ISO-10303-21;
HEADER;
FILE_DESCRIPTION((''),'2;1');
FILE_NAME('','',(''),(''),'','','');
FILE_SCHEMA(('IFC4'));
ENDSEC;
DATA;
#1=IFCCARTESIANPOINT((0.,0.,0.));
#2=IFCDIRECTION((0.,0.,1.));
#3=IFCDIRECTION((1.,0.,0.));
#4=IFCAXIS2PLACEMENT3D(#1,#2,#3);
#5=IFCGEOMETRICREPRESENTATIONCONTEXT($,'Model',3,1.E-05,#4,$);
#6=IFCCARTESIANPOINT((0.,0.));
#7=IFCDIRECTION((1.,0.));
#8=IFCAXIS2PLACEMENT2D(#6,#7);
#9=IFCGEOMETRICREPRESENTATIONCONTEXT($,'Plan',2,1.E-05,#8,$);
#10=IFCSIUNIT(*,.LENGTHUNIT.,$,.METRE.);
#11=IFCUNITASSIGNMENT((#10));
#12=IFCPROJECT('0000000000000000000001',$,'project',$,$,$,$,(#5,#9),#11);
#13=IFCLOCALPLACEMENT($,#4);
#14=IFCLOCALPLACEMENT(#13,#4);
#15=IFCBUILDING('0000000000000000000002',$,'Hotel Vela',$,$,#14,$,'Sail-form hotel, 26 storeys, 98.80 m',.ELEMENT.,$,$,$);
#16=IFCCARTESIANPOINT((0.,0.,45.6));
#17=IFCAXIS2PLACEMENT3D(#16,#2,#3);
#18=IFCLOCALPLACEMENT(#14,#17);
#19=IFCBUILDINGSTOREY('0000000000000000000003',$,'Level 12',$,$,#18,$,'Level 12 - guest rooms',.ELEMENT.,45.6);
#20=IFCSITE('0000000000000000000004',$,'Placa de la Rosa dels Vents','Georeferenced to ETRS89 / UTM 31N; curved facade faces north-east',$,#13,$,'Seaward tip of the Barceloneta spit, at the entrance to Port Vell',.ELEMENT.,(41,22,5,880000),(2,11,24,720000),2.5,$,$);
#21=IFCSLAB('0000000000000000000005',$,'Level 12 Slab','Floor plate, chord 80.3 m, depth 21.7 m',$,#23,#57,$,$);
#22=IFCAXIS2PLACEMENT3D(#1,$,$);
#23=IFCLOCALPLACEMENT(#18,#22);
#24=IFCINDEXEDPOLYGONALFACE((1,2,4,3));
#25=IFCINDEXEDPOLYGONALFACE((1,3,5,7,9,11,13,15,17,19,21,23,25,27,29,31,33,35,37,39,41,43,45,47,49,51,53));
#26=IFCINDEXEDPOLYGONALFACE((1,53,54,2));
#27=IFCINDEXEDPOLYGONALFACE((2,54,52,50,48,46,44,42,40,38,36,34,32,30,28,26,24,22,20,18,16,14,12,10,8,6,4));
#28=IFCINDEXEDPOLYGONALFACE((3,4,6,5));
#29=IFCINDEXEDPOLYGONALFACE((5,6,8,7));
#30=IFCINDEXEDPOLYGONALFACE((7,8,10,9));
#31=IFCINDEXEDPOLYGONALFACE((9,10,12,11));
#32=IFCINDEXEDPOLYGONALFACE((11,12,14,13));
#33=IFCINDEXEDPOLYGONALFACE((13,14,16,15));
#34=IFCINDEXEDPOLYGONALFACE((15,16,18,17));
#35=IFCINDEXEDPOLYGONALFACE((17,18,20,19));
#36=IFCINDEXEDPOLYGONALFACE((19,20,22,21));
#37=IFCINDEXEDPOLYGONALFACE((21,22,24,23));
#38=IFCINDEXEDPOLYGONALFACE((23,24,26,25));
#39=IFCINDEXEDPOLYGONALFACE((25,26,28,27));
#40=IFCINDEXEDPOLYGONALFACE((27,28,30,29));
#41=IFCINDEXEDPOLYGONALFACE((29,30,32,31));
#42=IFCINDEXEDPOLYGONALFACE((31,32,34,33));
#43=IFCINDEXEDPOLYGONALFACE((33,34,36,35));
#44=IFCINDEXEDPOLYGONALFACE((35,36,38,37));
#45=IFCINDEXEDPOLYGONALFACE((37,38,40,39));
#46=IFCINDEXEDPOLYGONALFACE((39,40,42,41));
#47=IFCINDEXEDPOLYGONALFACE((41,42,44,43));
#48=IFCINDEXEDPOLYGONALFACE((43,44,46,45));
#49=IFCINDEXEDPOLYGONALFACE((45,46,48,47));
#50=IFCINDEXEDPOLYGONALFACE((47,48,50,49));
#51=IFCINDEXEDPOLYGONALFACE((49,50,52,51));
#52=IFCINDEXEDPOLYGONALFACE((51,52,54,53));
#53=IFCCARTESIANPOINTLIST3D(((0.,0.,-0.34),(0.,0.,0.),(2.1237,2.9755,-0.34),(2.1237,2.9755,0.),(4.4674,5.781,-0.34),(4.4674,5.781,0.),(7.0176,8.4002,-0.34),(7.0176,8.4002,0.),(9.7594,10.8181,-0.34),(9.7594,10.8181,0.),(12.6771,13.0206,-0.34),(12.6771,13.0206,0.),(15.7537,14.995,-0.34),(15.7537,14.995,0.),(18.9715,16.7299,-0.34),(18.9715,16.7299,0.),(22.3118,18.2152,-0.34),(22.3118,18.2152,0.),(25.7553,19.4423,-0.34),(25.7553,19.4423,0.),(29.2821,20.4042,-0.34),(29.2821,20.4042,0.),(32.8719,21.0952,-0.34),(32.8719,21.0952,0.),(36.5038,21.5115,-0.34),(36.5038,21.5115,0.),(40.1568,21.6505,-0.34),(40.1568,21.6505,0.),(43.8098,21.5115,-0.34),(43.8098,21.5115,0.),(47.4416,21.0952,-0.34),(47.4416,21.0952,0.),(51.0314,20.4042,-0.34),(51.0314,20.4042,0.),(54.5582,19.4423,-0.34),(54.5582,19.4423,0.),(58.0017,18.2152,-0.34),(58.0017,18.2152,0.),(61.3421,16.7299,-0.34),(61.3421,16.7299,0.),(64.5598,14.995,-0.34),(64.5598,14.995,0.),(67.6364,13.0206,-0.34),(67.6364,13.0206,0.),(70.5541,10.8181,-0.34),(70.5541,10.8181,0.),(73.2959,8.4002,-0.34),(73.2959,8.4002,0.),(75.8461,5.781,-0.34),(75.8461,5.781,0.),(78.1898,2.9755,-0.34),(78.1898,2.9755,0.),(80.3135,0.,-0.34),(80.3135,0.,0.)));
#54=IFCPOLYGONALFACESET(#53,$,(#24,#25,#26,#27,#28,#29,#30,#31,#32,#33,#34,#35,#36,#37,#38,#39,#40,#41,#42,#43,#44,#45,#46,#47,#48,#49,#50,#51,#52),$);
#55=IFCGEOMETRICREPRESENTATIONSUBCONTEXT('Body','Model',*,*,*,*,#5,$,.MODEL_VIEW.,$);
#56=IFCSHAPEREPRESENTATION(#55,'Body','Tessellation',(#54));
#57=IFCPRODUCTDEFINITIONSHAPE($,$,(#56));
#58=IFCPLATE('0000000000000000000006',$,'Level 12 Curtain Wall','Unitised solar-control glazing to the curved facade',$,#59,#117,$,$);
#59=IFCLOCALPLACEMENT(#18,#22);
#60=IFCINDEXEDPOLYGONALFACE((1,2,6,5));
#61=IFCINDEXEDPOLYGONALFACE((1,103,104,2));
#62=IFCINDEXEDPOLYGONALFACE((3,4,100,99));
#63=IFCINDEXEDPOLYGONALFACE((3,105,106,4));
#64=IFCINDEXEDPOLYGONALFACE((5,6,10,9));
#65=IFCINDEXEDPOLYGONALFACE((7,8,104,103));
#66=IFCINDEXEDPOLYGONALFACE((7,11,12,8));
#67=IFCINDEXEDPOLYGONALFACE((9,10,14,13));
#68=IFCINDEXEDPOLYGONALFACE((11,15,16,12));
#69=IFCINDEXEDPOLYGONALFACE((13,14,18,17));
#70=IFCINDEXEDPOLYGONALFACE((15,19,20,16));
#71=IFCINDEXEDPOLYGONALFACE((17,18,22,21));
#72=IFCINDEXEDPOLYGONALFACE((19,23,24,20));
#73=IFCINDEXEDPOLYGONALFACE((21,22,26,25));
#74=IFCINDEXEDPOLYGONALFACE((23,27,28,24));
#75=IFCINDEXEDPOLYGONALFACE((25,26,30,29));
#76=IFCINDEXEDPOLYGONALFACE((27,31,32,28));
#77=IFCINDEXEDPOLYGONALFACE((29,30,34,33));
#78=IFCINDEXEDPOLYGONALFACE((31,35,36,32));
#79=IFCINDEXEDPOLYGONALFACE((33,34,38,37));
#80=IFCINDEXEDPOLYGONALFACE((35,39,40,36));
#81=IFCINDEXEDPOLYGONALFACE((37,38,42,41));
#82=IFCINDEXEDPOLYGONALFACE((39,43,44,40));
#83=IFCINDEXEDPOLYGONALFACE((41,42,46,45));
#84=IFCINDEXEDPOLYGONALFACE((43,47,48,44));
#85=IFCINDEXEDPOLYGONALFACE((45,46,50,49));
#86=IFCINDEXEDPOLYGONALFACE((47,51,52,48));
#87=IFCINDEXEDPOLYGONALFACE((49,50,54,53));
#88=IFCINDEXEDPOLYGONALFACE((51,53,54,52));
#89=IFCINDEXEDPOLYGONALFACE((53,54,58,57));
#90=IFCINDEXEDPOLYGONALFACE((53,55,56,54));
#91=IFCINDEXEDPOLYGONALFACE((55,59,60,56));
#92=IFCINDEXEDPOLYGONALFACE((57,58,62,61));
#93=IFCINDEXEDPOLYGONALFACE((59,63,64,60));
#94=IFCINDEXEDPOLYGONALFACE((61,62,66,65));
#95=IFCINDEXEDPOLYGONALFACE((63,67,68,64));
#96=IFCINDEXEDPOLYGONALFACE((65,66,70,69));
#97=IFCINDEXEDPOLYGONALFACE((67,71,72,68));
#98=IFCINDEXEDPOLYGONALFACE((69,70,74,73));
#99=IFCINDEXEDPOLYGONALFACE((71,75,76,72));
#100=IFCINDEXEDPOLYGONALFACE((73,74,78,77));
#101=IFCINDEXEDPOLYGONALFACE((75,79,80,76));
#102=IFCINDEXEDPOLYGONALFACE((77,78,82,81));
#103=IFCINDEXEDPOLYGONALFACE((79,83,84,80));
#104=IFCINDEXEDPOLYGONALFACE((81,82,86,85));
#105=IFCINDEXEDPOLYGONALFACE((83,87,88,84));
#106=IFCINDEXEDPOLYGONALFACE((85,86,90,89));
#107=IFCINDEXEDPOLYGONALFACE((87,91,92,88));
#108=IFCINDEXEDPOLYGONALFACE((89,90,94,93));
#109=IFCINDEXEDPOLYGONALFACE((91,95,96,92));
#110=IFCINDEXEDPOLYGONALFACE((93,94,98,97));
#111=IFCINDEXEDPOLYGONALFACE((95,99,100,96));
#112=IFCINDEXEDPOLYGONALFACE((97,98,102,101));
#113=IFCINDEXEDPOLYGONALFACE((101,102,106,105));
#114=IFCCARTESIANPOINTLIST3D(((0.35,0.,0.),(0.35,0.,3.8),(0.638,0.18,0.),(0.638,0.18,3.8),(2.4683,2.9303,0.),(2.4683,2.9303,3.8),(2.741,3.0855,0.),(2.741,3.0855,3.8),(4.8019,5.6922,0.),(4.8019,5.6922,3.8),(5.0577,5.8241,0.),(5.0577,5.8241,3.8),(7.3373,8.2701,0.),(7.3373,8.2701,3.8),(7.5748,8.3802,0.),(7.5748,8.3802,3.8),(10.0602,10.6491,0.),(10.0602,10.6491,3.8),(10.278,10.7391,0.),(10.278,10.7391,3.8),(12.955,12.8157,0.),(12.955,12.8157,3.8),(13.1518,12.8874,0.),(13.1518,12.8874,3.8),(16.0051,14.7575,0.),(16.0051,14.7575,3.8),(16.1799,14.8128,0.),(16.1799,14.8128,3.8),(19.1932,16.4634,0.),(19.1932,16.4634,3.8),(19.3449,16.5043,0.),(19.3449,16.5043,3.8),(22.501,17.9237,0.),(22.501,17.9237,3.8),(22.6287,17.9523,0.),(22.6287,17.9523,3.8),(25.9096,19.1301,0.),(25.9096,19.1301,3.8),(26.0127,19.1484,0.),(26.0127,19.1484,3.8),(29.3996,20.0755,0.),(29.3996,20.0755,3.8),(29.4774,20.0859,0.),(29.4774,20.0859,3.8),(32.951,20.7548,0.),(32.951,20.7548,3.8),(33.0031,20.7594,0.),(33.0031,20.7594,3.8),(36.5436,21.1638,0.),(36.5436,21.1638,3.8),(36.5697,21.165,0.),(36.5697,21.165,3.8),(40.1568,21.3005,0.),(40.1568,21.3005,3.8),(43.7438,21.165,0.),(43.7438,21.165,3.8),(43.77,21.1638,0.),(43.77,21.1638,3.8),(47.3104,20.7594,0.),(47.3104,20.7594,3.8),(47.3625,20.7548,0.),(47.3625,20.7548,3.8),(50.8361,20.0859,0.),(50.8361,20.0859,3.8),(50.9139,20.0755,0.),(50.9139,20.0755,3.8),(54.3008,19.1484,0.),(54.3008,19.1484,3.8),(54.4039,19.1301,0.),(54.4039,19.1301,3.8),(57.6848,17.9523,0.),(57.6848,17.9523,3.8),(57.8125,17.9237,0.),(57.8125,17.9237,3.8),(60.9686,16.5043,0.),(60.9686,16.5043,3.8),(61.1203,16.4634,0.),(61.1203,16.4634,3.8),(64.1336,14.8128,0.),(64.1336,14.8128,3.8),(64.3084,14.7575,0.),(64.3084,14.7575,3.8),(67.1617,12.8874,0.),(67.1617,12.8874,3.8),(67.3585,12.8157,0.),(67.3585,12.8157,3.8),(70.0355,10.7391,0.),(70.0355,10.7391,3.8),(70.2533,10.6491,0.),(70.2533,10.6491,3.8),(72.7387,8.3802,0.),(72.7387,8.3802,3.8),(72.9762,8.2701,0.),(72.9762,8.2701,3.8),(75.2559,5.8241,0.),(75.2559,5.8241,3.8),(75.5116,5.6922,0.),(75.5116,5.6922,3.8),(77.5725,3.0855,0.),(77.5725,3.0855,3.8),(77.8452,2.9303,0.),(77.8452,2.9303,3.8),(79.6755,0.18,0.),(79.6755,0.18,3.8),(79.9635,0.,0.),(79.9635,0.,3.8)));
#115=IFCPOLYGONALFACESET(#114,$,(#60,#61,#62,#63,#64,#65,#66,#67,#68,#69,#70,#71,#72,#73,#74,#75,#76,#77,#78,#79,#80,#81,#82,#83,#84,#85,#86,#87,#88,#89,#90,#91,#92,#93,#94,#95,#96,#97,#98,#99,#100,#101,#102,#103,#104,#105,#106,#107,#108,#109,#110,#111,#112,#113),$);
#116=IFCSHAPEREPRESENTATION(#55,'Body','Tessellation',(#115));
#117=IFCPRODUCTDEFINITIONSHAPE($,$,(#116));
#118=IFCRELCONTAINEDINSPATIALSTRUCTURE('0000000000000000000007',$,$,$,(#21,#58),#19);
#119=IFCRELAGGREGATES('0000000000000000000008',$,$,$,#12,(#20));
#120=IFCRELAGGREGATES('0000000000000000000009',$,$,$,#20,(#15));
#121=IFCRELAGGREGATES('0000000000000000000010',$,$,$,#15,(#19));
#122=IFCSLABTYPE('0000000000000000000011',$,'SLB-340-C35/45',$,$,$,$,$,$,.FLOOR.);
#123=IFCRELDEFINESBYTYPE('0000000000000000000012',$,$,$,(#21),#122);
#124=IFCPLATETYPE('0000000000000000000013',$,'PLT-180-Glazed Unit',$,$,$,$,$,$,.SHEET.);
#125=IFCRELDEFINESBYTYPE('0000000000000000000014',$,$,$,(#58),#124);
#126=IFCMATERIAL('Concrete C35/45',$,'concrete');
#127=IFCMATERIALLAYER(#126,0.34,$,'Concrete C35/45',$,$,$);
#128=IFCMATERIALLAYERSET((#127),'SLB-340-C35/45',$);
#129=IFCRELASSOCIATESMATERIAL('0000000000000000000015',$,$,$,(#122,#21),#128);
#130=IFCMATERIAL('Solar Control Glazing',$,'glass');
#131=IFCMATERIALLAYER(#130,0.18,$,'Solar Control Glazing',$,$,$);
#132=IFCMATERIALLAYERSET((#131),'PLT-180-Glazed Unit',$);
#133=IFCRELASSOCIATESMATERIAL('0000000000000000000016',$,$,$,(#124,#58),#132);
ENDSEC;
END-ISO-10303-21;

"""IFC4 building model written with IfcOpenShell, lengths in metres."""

from ifc_helpers import new_model, si_unit, frame, origin_with_axes, origin_2d_with_axis, place, context, subcontext, project, spatial, line, indexed_curve, outline, extrude, material, layer, layer_set, layer_usage, type_object, element, save


model = new_model("IFC4")

# Units and contexts
model_context = context("Model", 3, precision=1e-05, world=origin_with_axes())
plan_context = context("Plan", 2, precision=1e-05, world=origin_2d_with_axis())
body_context = subcontext(model_context, "Body", "Model", "MODEL_VIEW")
ifc_project = project(units=[si_unit("LENGTHUNIT", "METRE")], contexts=[model_context, plan_context])

# Site, building, storey
site_placement = place(None, origin_with_axes())
site = spatial("IfcSite", under=ifc_project, at=site_placement, Name="Placa de la Rosa dels Vents", Description="Georeferenced to ETRS89 / UTM 31N; curved facade faces north-east", LongName="Seaward tip of the Barceloneta spit, at the entrance to Port Vell", CompositionType="ELEMENT", RefLatitude=(41, 22, 5, 880000), RefLongitude=(2, 11, 24, 720000), RefElevation=2.5)
building_placement = place(site_placement, origin_with_axes())
building = spatial("IfcBuilding", under=site, at=building_placement, Name="Hotel Vela", LongName="Sail-form hotel, 26 storeys, 98.80 m", CompositionType="ELEMENT")
storey_placement = place(building_placement, frame((0.0, 0.0, 45.6), z_axis=(0.0, 0.0, 1.0), x_axis=(1.0, 0.0, 0.0)))
storey = spatial("IfcBuildingStorey", under=building, at=storey_placement, Name="Level 12", LongName="Level 12 - guest rooms", CompositionType="ELEMENT", Elevation=45.6)

# Slab
ifc_material_1 = material(Name="Concrete C35/45", Category="concrete")
ifc_layer_1 = layer(ifc_material_1, 0.34, Name="Concrete C35/45")
ifc_layer_set_1 = layer_set([ifc_layer_1], Name="SLB-340-C35/45")
ifc_layer_usage_1 = layer_usage(ifc_layer_set_1, "AXIS3", "POSITIVE", 0.0)
slab_type = type_object("IfcSlabType", Name="SLB-340-C35/45", PredefinedType="FLOOR", material=ifc_layer_set_1)
slab_placement = place(storey_placement, frame((0.0, 0.0, -0.34), z_axis=(0.0, 0.0, 1.0), x_axis=(1.0, 0.0, 0.0)))
element("IfcSlab", 1, at=slab_placement, inside=storey, type_object=slab_type, material=ifc_layer_usage_1, Name="Level 12 Slab", Description="Floor plate, chord 80.3 m, depth 21.7 m", context=body_context, shape_type="SweptSolid", body=[
    extrude(outline(indexed_curve([(0.0, 0.0), (80.3135, 0.0), (78.1898, 2.9755), (75.8461, 5.781), (73.2959, 8.4002), (70.5541, 10.8181), (67.6364, 13.0206), (64.5598, 14.995), (61.3421, 16.7299), (58.0017, 18.2152), (54.5582, 19.4423), (51.0314, 20.4042), (47.4416, 21.0952), (43.8098, 21.5115), (40.1568, 21.6505), (36.5038, 21.5115), (32.8719, 21.0952), (29.2821, 20.4042), (25.7553, 19.4423), (22.3118, 18.2152), (18.9715, 16.7299), (15.7537, 14.995), (12.6771, 13.0206), (9.7594, 10.8181), (7.0176, 8.4002), (4.4674, 5.781), (2.1237, 2.9755)], segments=[line(1, 2, 3, 4, 5, 6, 7, 8, 9, 10, 11, 12, 13, 14, 15, 16, 17, 18, 19, 20, 21, 22, 23, 24, 25, 26, 27, 1)])), origin_with_axes(), (0.0, 0.0, 1.0), 0.34),
])

# Plate
ifc_material_2 = material(Name="Solar Control Glazing", Category="glass")
ifc_layer_2 = layer(ifc_material_2, 0.18, Name="Solar Control Glazing")
ifc_layer_set_2 = layer_set([ifc_layer_2], Name="PLT-180-Glazed Unit")
ifc_layer_usage_2 = layer_usage(ifc_layer_set_2, "AXIS2", "POSITIVE", 0.0)
plate_type_1 = type_object("IfcPlateType", Name="PLT-180-Glazed Unit", PredefinedType="SHEET", material=ifc_layer_set_2)
plate_1_placement = place(storey_placement, frame((0.35, 0.0, 0.0), z_axis=(0.0, 0.0, 1.0), x_axis=(1.0, 0.0, 0.0)))
element("IfcPlate", 2, at=plate_1_placement, inside=storey, type_object=plate_type_1, material=ifc_layer_usage_2, Name="Level 12 Curtain Wall", Description="Unitised solar-control glazing to the curved facade", context=body_context, shape_type="SweptSolid", body=[
    extrude(outline(indexed_curve([(79.6135, 0.0), (77.4952, 2.9303), (75.1616, 5.6922), (72.6262, 8.2701), (69.9033, 10.6491), (67.0085, 12.8157), (63.9584, 14.7575), (60.7703, 16.4634), (57.4625, 17.9237), (54.0539, 19.1301), (50.5639, 20.0755), (47.0125, 20.7548), (43.42, 21.1638), (39.8068, 21.3005), (36.1936, 21.1638), (32.601, 20.7548), (29.0496, 20.0755), (25.5596, 19.1301), (22.151, 17.9237), (18.8432, 16.4634), (15.6551, 14.7575), (12.605, 12.8157), (9.7102, 10.6491), (6.9873, 8.2701), (4.4519, 5.6922), (2.1183, 2.9303), (0.0, 0.0), (79.3255, 0.18), (2.391, 3.0855), (4.7077, 5.8241), (7.2248, 8.3802), (9.928, 10.7391), (12.8018, 12.8874), (15.8299, 14.8128), (18.9949, 16.5043), (22.2787, 17.9523), (25.6627, 19.1484), (29.1274, 20.0859), (32.6531, 20.7594), (36.2197, 21.165), (39.8068, 21.3005), (43.3938, 21.165), (46.9604, 20.7594), (50.4861, 20.0859), (53.9508, 19.1484), (57.3348, 17.9523), (60.6186, 16.5043), (63.7836, 14.8128), (66.8117, 12.8874), (69.6855, 10.7391), (72.3887, 8.3802), (74.9059, 5.8241), (77.2225, 3.0855), (0.288, 0.18)], segments=[line(1, 2, 3, 4, 5, 6, 7, 8, 9, 10, 11, 12, 13, 14, 15, 16, 17, 18, 19, 20, 21, 22, 23, 24, 25, 26, 27, 28, 29, 30, 31, 32, 33, 34, 35, 36, 37, 38, 39, 40, 41, 42, 43, 44, 45, 46, 47, 48, 49, 50, 51, 52, 53, 54, 1)])), origin_with_axes(), (0.0, 0.0, 1.0), 3.8),
])

save(model, "model.ifc")
